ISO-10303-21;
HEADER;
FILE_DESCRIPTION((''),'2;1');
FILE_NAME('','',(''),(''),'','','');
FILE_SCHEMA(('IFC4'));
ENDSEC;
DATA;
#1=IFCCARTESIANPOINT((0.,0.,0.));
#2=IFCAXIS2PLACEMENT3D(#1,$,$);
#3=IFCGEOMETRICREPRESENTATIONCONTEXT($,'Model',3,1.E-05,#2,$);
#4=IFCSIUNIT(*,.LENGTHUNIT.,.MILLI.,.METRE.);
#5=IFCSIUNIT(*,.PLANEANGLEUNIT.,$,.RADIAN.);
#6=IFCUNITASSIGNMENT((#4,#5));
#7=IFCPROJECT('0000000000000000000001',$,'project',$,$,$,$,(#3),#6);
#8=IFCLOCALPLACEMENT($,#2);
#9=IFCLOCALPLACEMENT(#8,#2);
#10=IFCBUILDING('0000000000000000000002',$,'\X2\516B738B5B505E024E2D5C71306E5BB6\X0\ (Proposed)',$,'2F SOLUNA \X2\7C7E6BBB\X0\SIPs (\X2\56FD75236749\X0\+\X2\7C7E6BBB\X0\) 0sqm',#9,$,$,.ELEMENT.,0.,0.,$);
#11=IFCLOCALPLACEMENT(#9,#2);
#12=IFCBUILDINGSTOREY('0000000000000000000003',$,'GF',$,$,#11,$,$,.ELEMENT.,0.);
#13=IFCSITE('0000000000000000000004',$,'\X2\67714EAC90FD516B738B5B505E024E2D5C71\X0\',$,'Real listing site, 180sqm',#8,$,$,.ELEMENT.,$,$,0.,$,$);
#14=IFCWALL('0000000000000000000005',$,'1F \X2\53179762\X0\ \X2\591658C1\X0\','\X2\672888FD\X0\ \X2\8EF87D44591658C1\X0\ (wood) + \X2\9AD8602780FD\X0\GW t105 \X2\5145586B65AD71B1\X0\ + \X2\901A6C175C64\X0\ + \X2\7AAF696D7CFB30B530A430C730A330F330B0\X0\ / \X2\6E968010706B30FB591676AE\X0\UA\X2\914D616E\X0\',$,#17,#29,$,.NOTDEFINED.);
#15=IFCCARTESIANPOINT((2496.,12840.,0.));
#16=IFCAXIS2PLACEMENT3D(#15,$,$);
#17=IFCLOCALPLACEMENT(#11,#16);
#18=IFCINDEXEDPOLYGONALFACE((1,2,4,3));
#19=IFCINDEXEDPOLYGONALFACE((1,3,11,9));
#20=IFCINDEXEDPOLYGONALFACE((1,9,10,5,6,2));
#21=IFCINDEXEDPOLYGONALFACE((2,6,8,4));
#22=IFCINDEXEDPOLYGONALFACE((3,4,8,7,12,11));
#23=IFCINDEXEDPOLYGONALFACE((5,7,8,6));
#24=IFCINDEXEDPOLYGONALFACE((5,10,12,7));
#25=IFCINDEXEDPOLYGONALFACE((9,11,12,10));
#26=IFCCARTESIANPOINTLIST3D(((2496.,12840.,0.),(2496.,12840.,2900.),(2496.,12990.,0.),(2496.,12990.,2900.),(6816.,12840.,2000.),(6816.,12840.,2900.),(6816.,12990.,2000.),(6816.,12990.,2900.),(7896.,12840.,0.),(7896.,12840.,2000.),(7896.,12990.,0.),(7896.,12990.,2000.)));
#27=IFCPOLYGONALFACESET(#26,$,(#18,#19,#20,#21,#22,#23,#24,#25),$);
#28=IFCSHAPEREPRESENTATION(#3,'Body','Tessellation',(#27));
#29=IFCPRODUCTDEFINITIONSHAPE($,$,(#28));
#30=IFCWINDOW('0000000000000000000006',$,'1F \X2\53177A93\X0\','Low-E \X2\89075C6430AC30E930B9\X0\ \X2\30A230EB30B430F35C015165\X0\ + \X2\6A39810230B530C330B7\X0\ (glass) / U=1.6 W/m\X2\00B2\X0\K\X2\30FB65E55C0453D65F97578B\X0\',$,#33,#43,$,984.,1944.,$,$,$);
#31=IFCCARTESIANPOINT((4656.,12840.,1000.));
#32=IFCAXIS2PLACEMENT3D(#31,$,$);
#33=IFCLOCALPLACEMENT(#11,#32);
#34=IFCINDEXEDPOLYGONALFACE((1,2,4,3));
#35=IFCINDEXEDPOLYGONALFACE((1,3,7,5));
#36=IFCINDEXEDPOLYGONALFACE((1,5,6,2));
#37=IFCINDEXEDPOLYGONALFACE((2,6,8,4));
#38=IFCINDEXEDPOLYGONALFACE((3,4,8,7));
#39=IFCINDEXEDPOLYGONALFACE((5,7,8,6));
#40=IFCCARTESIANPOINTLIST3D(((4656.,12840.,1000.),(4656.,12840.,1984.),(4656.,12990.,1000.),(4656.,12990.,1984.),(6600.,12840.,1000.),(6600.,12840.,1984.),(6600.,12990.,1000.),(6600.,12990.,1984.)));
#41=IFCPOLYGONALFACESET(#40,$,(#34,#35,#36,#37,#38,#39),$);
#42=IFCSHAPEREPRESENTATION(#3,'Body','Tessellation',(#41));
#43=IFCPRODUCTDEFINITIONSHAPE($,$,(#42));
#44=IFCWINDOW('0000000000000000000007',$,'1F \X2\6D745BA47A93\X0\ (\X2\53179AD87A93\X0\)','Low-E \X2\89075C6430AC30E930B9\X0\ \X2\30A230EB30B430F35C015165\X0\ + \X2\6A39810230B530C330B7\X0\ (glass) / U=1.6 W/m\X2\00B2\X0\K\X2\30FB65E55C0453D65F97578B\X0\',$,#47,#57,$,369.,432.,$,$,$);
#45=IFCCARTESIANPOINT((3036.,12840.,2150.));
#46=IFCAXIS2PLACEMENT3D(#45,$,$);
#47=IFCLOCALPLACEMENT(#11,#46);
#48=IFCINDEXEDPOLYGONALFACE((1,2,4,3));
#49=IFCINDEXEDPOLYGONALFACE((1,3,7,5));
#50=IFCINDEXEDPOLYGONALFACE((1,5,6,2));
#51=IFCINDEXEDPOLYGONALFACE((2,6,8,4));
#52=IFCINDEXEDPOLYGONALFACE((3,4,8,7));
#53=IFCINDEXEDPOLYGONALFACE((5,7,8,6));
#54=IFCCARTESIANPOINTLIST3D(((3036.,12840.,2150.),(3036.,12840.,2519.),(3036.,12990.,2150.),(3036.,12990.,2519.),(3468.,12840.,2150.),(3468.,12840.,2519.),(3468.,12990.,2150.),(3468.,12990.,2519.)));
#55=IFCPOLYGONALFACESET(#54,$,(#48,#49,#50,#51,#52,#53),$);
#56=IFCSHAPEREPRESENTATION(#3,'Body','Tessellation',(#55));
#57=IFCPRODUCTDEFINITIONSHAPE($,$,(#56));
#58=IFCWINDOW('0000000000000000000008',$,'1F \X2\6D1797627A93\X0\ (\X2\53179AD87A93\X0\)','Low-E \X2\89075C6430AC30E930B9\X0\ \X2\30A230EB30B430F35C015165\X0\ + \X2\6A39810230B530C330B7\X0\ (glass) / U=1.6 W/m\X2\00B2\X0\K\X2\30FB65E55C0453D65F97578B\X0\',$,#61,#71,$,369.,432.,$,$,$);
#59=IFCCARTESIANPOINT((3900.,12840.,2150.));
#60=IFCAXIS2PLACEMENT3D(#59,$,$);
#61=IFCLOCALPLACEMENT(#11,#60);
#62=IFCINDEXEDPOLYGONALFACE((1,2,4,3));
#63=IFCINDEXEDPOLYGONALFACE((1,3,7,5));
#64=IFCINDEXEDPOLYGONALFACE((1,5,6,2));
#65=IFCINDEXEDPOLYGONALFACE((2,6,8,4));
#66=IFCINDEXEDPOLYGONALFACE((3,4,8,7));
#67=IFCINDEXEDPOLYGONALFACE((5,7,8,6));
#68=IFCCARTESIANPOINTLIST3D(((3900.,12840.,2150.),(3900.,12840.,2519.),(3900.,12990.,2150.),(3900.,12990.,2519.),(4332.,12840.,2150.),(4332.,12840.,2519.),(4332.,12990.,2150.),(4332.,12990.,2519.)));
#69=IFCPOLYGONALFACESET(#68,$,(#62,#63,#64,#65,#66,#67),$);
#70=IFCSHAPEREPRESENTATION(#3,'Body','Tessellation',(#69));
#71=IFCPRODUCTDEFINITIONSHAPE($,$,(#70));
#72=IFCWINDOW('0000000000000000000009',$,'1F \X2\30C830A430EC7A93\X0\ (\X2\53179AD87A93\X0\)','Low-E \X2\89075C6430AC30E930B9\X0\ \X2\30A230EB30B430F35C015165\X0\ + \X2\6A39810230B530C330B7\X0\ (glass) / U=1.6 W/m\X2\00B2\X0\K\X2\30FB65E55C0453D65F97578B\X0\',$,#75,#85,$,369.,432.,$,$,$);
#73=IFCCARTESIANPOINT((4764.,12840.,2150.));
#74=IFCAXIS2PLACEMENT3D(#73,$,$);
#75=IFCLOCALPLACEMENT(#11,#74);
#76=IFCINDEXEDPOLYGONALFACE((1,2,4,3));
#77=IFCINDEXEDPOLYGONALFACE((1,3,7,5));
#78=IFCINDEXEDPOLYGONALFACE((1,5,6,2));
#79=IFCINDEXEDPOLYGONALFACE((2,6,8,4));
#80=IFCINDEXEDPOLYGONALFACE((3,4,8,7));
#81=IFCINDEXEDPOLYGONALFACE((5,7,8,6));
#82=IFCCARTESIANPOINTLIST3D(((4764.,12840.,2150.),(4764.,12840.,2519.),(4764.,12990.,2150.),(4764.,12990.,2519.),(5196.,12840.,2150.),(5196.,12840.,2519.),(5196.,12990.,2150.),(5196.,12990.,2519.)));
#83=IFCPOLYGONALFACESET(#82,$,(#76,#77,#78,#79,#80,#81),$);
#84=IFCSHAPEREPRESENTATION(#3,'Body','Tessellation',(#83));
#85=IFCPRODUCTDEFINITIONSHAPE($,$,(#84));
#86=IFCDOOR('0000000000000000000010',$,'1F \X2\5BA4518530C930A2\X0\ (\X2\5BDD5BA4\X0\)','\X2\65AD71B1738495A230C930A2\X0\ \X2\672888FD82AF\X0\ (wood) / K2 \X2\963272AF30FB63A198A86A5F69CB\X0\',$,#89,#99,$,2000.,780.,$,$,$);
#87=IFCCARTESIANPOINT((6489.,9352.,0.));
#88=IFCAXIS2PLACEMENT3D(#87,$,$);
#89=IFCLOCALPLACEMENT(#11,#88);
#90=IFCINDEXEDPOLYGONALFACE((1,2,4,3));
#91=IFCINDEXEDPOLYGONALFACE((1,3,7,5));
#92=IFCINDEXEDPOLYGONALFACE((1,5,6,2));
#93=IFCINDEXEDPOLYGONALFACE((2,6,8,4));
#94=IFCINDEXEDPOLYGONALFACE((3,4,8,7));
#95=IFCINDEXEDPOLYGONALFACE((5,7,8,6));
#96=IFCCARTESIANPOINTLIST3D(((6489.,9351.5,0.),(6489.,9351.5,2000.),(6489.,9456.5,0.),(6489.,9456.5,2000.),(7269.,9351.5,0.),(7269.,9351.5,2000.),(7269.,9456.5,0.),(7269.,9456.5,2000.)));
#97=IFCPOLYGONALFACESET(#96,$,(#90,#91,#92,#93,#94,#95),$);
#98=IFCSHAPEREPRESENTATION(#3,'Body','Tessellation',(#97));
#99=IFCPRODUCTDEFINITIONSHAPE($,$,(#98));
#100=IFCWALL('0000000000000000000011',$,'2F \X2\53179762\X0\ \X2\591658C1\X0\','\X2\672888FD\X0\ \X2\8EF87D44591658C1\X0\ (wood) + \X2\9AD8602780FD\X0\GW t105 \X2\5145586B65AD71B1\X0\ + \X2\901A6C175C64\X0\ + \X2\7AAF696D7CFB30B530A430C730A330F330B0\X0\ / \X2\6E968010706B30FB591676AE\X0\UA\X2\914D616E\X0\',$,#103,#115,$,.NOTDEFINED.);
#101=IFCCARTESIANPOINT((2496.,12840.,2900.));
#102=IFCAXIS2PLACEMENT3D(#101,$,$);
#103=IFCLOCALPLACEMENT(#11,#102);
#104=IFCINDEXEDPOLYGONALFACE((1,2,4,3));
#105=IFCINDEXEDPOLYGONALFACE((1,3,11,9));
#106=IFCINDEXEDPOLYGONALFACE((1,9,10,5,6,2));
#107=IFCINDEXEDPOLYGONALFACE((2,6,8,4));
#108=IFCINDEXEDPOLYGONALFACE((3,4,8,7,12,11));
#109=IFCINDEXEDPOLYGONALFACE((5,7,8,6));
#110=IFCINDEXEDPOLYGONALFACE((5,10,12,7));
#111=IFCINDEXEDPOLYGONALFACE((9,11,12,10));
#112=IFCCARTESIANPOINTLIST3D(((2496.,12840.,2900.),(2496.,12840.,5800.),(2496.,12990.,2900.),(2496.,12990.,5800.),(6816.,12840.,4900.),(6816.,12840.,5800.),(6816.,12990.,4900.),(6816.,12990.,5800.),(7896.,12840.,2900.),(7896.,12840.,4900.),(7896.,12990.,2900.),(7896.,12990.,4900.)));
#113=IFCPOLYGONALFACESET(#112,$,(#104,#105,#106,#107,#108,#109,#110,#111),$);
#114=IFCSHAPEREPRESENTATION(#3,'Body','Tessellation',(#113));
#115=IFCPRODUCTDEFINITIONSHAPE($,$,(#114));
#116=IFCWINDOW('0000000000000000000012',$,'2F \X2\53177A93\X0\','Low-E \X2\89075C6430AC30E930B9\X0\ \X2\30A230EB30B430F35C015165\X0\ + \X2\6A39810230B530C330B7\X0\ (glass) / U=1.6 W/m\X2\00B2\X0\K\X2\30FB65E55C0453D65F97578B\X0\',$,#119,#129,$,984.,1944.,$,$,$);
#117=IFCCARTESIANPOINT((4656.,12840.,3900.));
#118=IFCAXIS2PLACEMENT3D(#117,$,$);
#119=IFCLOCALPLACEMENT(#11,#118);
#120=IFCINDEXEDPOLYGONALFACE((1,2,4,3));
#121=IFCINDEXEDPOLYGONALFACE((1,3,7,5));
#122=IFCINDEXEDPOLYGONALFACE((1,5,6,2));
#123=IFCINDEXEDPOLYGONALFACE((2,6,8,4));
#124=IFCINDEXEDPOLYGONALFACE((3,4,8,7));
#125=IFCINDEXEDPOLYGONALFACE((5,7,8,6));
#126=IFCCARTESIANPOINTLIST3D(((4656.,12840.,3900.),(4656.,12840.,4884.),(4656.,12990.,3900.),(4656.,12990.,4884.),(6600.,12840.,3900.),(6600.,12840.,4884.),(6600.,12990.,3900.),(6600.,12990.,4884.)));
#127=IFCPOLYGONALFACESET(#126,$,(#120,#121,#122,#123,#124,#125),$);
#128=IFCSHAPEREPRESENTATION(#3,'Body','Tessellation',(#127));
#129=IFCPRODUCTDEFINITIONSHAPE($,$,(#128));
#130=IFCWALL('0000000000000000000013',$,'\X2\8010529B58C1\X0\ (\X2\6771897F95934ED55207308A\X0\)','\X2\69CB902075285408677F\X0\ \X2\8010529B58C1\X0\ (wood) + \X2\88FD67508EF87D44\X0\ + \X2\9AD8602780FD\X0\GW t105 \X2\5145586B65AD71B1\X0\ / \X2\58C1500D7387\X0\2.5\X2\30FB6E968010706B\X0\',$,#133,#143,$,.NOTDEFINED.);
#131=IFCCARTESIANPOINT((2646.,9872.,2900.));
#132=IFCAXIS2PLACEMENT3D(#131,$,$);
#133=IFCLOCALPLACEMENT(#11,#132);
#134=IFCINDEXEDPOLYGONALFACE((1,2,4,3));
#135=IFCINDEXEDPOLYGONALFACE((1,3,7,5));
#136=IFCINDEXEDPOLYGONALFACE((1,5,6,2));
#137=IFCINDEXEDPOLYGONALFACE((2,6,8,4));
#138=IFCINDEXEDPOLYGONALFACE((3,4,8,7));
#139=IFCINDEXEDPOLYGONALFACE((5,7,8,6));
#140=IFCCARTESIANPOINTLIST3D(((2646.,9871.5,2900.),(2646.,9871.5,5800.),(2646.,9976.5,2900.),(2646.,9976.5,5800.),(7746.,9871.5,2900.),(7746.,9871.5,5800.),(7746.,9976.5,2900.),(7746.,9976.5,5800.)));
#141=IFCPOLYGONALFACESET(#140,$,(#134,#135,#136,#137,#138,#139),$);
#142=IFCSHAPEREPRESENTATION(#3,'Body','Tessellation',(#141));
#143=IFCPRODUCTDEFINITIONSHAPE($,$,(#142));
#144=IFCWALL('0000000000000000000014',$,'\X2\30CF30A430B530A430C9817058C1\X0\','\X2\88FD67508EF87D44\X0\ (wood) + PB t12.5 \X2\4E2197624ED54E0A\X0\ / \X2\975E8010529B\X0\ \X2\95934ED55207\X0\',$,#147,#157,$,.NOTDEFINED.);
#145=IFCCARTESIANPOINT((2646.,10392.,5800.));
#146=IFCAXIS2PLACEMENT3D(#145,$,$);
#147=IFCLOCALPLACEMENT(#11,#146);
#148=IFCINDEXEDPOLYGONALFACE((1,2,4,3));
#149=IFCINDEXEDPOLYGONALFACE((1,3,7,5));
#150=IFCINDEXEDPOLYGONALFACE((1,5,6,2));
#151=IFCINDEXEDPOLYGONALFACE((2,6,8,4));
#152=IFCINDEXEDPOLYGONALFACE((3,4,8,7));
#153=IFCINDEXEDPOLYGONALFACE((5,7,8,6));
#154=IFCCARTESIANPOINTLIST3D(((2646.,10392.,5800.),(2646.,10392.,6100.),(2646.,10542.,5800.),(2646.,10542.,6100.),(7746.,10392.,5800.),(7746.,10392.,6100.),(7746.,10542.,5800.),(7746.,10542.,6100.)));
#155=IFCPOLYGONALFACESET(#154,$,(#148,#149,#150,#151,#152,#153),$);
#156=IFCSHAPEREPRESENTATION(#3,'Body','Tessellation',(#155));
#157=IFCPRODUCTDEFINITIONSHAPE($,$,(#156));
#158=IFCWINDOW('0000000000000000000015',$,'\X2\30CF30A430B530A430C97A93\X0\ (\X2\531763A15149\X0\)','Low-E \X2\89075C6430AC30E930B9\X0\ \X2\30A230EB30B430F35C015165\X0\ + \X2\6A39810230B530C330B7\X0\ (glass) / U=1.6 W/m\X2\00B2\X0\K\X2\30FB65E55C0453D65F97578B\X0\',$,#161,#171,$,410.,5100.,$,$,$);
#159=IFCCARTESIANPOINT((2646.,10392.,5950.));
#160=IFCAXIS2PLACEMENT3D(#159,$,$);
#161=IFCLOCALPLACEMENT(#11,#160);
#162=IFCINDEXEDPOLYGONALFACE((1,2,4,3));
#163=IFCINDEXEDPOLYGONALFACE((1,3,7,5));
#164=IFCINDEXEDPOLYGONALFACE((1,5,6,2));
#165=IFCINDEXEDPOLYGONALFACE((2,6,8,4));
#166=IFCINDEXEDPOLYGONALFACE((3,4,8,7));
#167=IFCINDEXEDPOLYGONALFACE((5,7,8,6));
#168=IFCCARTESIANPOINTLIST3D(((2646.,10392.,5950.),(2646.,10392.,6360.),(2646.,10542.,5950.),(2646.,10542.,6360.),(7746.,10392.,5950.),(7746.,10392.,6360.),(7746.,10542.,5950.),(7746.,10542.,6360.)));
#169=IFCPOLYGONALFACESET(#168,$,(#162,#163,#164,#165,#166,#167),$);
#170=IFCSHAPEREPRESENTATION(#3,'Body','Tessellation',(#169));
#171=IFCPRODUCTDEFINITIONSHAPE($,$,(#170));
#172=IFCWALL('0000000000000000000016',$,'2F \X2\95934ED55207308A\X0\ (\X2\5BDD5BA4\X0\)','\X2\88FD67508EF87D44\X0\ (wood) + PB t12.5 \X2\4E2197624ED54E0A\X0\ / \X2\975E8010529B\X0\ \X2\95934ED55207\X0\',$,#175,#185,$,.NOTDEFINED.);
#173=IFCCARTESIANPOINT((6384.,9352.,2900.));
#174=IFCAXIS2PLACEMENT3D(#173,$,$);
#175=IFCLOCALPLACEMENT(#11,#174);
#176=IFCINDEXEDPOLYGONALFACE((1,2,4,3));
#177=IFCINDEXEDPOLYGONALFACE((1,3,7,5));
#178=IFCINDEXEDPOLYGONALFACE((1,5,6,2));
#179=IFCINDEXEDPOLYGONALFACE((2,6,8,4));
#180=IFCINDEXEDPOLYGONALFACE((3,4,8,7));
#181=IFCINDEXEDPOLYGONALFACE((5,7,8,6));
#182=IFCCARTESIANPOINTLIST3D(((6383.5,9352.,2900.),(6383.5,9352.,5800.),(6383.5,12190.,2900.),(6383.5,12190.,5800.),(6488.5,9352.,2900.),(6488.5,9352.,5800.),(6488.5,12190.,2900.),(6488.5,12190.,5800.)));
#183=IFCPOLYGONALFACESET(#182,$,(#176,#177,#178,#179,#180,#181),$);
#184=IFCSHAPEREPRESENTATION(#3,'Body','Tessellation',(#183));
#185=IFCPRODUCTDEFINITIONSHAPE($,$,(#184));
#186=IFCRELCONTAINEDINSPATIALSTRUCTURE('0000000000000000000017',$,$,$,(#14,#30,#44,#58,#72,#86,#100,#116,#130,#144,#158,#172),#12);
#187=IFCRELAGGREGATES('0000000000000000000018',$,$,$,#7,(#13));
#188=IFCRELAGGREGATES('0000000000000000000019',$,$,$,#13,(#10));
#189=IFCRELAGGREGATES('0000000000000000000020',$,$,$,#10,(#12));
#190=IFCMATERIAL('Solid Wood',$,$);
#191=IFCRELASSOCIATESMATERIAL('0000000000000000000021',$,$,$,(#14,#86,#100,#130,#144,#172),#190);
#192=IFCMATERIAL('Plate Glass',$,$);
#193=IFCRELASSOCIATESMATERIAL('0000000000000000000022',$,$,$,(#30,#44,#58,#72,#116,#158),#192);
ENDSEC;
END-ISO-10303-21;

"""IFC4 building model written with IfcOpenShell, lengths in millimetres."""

from ifc_helpers import new_model, si_unit, frame, frame_2d, origin, place, context, project, spatial, rectangle, extrude, material, element, fill, save


model = new_model("IFC4")

# Units and contexts
model_context = context("Model", 3, precision=1e-05, world=origin())
ifc_project = project(units=[si_unit("LENGTHUNIT", "METRE", prefix="MILLI"), si_unit("PLANEANGLEUNIT", "RADIAN")], contexts=[model_context])

# Site, building, storey
site_placement = place(None, origin())
site = spatial("IfcSite", under=ifc_project, at=site_placement, Name="東京都八王子市中山", ObjectType="Real listing site, 180sqm", CompositionType="ELEMENT", RefElevation=0.0)
building_placement = place(site_placement, origin())
building = spatial("IfcBuilding", under=site, at=building_placement, Name="八王子市中山の家 (Proposed)", ObjectType="2F SOLUNA 籾殻SIPs (国産杉+籾殻) 0sqm", CompositionType="ELEMENT", ElevationOfRefHeight=0.0, ElevationOfTerrain=0.0)
storey_placement = place(building_placement, origin())
storey = spatial("IfcBuildingStorey", under=building, at=storey_placement, Name="GF", CompositionType="ELEMENT", Elevation=0.0)

# Wall, openings, windows
ifc_material_1 = material(Name="Solid Wood")
wall_1_placement = place(storey_placement, frame((2496.0, 12840.0, 0.0)))
wall_1 = element("IfcWall", 1, at=wall_1_placement, inside=storey, material=ifc_material_1, Name="1F 北面 外壁", Description="木製 軸組外壁 (wood) + 高性能GW t105 充填断熱 + 通気層 + 窯業系サイディング / 準耐火・外皮UA配慮", PredefinedType="NOTDEFINED", context=model_context, shape_type="SweptSolid", body=[
    extrude(rectangle(XDim=5400.0, YDim=150.0, at=frame_2d((2700.0, 75.0))), frame((2496.0, 12840.0, 0.0)), (0.0, 0.0, 1.0), 2900.0),
])
opening_1_placement = place(storey_placement, frame((4656.0, 12840.0, 1000.0)))
opening_1 = element("IfcOpeningElement", 2, at=opening_1_placement, cuts=wall_1, PredefinedType="NOTDEFINED", context=model_context, shape_type="SweptSolid", body=[
    extrude(rectangle(XDim=1944.0, YDim=150.0, at=frame_2d((972.0, 75.0))), frame((4656.0, 12840.0, 1000.0)), (0.0, 0.0, 1.0), 984.0),
])
opening_2_placement = place(storey_placement, frame((3036.0, 12840.0, 2150.0)))
opening_2 = element("IfcOpeningElement", 3, at=opening_2_placement, cuts=wall_1, PredefinedType="NOTDEFINED", context=model_context, shape_type="SweptSolid", body=[
    extrude(rectangle(XDim=432.0, YDim=150.0, at=frame_2d((216.0, 75.0))), frame((3036.0, 12840.0, 2150.0)), (0.0, 0.0, 1.0), 369.0),
])
opening_3_placement = place(storey_placement, frame((3900.0, 12840.0, 2150.0)))
opening_3 = element("IfcOpeningElement", 4, at=opening_3_placement, cuts=wall_1, PredefinedType="NOTDEFINED", context=model_context, shape_type="SweptSolid", body=[
    extrude(rectangle(XDim=432.0, YDim=150.0, at=frame_2d((216.0, 75.0))), frame((3900.0, 12840.0, 2150.0)), (0.0, 0.0, 1.0), 369.0),
])
opening_4_placement = place(storey_placement, frame((4764.0, 12840.0, 2150.0)))
opening_4 = element("IfcOpeningElement", 5, at=opening_4_placement, cuts=wall_1, PredefinedType="NOTDEFINED", context=model_context, shape_type="SweptSolid", body=[
    extrude(rectangle(XDim=432.0, YDim=150.0, at=frame_2d((216.0, 75.0))), frame((4764.0, 12840.0, 2150.0)), (0.0, 0.0, 1.0), 369.0),
])
ifc_material_2 = material(Name="Plate Glass")
window_1_placement = place(storey_placement, frame((4656.0, 12840.0, 1000.0)))
window_1 = element("IfcWindow", 6, at=window_1_placement, inside=storey, material=ifc_material_2, Name="1F 北窓", Description="Low-E 複層ガラス アルゴン封入 + 樹脂サッシ (glass) / U=1.6 W/m²K・日射取得型", OverallHeight=984.0, OverallWidth=1944.0, context=model_context, shape_type="SweptSolid", body=[
    extrude(rectangle(XDim=1944.0, YDim=150.0, at=frame_2d((972.0, 75.0))), frame((4656.0, 12840.0, 1000.0)), (0.0, 0.0, 1.0), 984.0),
])
fill(opening_1, window_1)
window_2_placement = place(storey_placement, frame((3036.0, 12840.0, 2150.0)))
window_2 = element("IfcWindow", 7, at=window_2_placement, inside=storey, material=ifc_material_2, Name="1F 浴室窓 (北高窓)", Description="Low-E 複層ガラス アルゴン封入 + 樹脂サッシ (glass) / U=1.6 W/m²K・日射取得型", OverallHeight=369.0, OverallWidth=432.0, context=model_context, shape_type="SweptSolid", body=[
    extrude(rectangle(XDim=432.0, YDim=150.0, at=frame_2d((216.0, 75.0))), frame((3036.0, 12840.0, 2150.0)), (0.0, 0.0, 1.0), 369.0),
])
fill(opening_2, window_2)
window_3_placement = place(storey_placement, frame((3900.0, 12840.0, 2150.0)))
window_3 = element("IfcWindow", 8, at=window_3_placement, inside=storey, material=ifc_material_2, Name="1F 洗面窓 (北高窓)", Description="Low-E 複層ガラス アルゴン封入 + 樹脂サッシ (glass) / U=1.6 W/m²K・日射取得型", OverallHeight=369.0, OverallWidth=432.0, context=model_context, shape_type="SweptSolid", body=[
    extrude(rectangle(XDim=432.0, YDim=150.0, at=frame_2d((216.0, 75.0))), frame((3900.0, 12840.0, 2150.0)), (0.0, 0.0, 1.0), 369.0),
])
fill(opening_3, window_3)
window_4_placement = place(storey_placement, frame((4764.0, 12840.0, 2150.0)))
window_4 = element("IfcWindow", 9, at=window_4_placement, inside=storey, material=ifc_material_2, Name="1F トイレ窓 (北高窓)", Description="Low-E 複層ガラス アルゴン封入 + 樹脂サッシ (glass) / U=1.6 W/m²K・日射取得型", OverallHeight=369.0, OverallWidth=432.0, context=model_context, shape_type="SweptSolid", body=[
    extrude(rectangle(XDim=432.0, YDim=150.0, at=frame_2d((216.0, 75.0))), frame((4764.0, 12840.0, 2150.0)), (0.0, 0.0, 1.0), 369.0),
])
fill(opening_4, window_4)

# Door
door_1_placement = place(storey_placement, frame((6489.0, 9352.0, 0.0)))
element("IfcDoor", 10, at=door_1_placement, inside=storey, material=ifc_material_1, Name="1F 室内ドア (寝室)", Description="断熱玄関ドア 木製芯 (wood) / K2 防犯・採風機構", OverallHeight=2000.0, OverallWidth=780.0, context=model_context, shape_type="SweptSolid", body=[
    extrude(rectangle(XDim=780.0, YDim=105.0, at=frame_2d((390.0, 52.0))), frame((6489.0, 9352.0, 0.0)), (0.0, 0.0, 1.0), 2000.0),
])

# Wall, opening, window
wall_2_placement = place(storey_placement, frame((2496.0, 12840.0, 2900.0)))
wall_2 = element("IfcWall", 11, at=wall_2_placement, inside=storey, material=ifc_material_1, Name="2F 北面 外壁", Description="木製 軸組外壁 (wood) + 高性能GW t105 充填断熱 + 通気層 + 窯業系サイディング / 準耐火・外皮UA配慮", PredefinedType="NOTDEFINED", context=model_context, shape_type="SweptSolid", body=[
    extrude(rectangle(XDim=5400.0, YDim=150.0, at=frame_2d((2700.0, 75.0))), frame((2496.0, 12840.0, 2900.0)), (0.0, 0.0, 1.0), 2900.0),
])
opening_5_placement = place(storey_placement, frame((4656.0, 12840.0, 3900.0)))
opening_5 = element("IfcOpeningElement", 12, at=opening_5_placement, cuts=wall_2, PredefinedType="NOTDEFINED", context=model_context, shape_type="SweptSolid", body=[
    extrude(rectangle(XDim=1944.0, YDim=150.0, at=frame_2d((972.0, 75.0))), frame((4656.0, 12840.0, 3900.0)), (0.0, 0.0, 1.0), 984.0),
])
window_5_placement = place(storey_placement, frame((4656.0, 12840.0, 3900.0)))
window_5 = element("IfcWindow", 13, at=window_5_placement, inside=storey, material=ifc_material_2, Name="2F 北窓", Description="Low-E 複層ガラス アルゴン封入 + 樹脂サッシ (glass) / U=1.6 W/m²K・日射取得型", OverallHeight=984.0, OverallWidth=1944.0, context=model_context, shape_type="SweptSolid", body=[
    extrude(rectangle(XDim=1944.0, YDim=150.0, at=frame_2d((972.0, 75.0))), frame((4656.0, 12840.0, 3900.0)), (0.0, 0.0, 1.0), 984.0),
])
fill(opening_5, window_5)

# Wall
wall_3_placement = place(storey_placement, frame((2646.0, 9872.0, 2900.0)))
element("IfcWall", 14, at=wall_3_placement, inside=storey, material=ifc_material_1, Name="耐力壁 (東西間仕切り)", Description="構造用合板 耐力壁 (wood) + 製材軸組 + 高性能GW t105 充填断熱 / 壁倍率2.5・準耐火", PredefinedType="NOTDEFINED", context=model_context, shape_type="SweptSolid", body=[
    extrude(rectangle(XDim=5100.0, YDim=105.0, at=frame_2d((2550.0, 52.0))), frame((2646.0, 9872.0, 2900.0)), (0.0, 0.0, 1.0), 2900.0),
])

# Wall, opening, window
wall_4_placement = place(storey_placement, frame((2646.0, 10392.0, 5800.0)))
wall_4 = element("IfcWall", 15, at=wall_4_placement, inside=storey, material=ifc_material_1, Name="ハイサイド腰壁", Description="製材軸組 (wood) + PB t12.5 両面仕上 / 非耐力 間仕切", PredefinedType="NOTDEFINED", context=model_context, shape_type="SweptSolid", body=[
    extrude(rectangle(XDim=5100.0, YDim=150.0, at=frame_2d((2550.0, 75.0))), frame((2646.0, 10392.0, 5800.0)), (0.0, 0.0, 1.0), 700.0),
])
opening_6_placement = place(storey_placement, frame((2646.0, 10392.0, 5950.0)))
opening_6 = element("IfcOpeningElement", 16, at=opening_6_placement, cuts=wall_4, PredefinedType="NOTDEFINED", context=model_context, shape_type="SweptSolid", body=[
    extrude(rectangle(XDim=5100.0, YDim=150.0, at=frame_2d((2550.0, 75.0))), frame((2646.0, 10392.0, 5950.0)), (0.0, 0.0, 1.0), 410.0),
])
window_6_placement = place(storey_placement, frame((2646.0, 10392.0, 5950.0)))
window_6 = element("IfcWindow", 17, at=window_6_placement, inside=storey, material=ifc_material_2, Name="ハイサイド窓 (北採光)", Description="Low-E 複層ガラス アルゴン封入 + 樹脂サッシ (glass) / U=1.6 W/m²K・日射取得型", OverallHeight=410.0, OverallWidth=5100.0, context=model_context, shape_type="SweptSolid", body=[
    extrude(rectangle(XDim=5100.0, YDim=150.0, at=frame_2d((2550.0, 75.0))), frame((2646.0, 10392.0, 5950.0)), (0.0, 0.0, 1.0), 410.0),
])
fill(opening_6, window_6)

# Wall
wall_5_placement = place(storey_placement, frame((6384.0, 9352.0, 2900.0)))
element("IfcWall", 18, at=wall_5_placement, inside=storey, material=ifc_material_1, Name="2F 間仕切り (寝室)", Description="製材軸組 (wood) + PB t12.5 両面仕上 / 非耐力 間仕切", PredefinedType="NOTDEFINED", context=model_context, shape_type="SweptSolid", body=[
    extrude(rectangle(XDim=105.0, YDim=2838.0, at=frame_2d((52.0, 1419.0))), frame((6384.0, 9352.0, 2900.0)), (0.0, 0.0, 1.0), 2900.0),
])

save(model, "model.ifc")
